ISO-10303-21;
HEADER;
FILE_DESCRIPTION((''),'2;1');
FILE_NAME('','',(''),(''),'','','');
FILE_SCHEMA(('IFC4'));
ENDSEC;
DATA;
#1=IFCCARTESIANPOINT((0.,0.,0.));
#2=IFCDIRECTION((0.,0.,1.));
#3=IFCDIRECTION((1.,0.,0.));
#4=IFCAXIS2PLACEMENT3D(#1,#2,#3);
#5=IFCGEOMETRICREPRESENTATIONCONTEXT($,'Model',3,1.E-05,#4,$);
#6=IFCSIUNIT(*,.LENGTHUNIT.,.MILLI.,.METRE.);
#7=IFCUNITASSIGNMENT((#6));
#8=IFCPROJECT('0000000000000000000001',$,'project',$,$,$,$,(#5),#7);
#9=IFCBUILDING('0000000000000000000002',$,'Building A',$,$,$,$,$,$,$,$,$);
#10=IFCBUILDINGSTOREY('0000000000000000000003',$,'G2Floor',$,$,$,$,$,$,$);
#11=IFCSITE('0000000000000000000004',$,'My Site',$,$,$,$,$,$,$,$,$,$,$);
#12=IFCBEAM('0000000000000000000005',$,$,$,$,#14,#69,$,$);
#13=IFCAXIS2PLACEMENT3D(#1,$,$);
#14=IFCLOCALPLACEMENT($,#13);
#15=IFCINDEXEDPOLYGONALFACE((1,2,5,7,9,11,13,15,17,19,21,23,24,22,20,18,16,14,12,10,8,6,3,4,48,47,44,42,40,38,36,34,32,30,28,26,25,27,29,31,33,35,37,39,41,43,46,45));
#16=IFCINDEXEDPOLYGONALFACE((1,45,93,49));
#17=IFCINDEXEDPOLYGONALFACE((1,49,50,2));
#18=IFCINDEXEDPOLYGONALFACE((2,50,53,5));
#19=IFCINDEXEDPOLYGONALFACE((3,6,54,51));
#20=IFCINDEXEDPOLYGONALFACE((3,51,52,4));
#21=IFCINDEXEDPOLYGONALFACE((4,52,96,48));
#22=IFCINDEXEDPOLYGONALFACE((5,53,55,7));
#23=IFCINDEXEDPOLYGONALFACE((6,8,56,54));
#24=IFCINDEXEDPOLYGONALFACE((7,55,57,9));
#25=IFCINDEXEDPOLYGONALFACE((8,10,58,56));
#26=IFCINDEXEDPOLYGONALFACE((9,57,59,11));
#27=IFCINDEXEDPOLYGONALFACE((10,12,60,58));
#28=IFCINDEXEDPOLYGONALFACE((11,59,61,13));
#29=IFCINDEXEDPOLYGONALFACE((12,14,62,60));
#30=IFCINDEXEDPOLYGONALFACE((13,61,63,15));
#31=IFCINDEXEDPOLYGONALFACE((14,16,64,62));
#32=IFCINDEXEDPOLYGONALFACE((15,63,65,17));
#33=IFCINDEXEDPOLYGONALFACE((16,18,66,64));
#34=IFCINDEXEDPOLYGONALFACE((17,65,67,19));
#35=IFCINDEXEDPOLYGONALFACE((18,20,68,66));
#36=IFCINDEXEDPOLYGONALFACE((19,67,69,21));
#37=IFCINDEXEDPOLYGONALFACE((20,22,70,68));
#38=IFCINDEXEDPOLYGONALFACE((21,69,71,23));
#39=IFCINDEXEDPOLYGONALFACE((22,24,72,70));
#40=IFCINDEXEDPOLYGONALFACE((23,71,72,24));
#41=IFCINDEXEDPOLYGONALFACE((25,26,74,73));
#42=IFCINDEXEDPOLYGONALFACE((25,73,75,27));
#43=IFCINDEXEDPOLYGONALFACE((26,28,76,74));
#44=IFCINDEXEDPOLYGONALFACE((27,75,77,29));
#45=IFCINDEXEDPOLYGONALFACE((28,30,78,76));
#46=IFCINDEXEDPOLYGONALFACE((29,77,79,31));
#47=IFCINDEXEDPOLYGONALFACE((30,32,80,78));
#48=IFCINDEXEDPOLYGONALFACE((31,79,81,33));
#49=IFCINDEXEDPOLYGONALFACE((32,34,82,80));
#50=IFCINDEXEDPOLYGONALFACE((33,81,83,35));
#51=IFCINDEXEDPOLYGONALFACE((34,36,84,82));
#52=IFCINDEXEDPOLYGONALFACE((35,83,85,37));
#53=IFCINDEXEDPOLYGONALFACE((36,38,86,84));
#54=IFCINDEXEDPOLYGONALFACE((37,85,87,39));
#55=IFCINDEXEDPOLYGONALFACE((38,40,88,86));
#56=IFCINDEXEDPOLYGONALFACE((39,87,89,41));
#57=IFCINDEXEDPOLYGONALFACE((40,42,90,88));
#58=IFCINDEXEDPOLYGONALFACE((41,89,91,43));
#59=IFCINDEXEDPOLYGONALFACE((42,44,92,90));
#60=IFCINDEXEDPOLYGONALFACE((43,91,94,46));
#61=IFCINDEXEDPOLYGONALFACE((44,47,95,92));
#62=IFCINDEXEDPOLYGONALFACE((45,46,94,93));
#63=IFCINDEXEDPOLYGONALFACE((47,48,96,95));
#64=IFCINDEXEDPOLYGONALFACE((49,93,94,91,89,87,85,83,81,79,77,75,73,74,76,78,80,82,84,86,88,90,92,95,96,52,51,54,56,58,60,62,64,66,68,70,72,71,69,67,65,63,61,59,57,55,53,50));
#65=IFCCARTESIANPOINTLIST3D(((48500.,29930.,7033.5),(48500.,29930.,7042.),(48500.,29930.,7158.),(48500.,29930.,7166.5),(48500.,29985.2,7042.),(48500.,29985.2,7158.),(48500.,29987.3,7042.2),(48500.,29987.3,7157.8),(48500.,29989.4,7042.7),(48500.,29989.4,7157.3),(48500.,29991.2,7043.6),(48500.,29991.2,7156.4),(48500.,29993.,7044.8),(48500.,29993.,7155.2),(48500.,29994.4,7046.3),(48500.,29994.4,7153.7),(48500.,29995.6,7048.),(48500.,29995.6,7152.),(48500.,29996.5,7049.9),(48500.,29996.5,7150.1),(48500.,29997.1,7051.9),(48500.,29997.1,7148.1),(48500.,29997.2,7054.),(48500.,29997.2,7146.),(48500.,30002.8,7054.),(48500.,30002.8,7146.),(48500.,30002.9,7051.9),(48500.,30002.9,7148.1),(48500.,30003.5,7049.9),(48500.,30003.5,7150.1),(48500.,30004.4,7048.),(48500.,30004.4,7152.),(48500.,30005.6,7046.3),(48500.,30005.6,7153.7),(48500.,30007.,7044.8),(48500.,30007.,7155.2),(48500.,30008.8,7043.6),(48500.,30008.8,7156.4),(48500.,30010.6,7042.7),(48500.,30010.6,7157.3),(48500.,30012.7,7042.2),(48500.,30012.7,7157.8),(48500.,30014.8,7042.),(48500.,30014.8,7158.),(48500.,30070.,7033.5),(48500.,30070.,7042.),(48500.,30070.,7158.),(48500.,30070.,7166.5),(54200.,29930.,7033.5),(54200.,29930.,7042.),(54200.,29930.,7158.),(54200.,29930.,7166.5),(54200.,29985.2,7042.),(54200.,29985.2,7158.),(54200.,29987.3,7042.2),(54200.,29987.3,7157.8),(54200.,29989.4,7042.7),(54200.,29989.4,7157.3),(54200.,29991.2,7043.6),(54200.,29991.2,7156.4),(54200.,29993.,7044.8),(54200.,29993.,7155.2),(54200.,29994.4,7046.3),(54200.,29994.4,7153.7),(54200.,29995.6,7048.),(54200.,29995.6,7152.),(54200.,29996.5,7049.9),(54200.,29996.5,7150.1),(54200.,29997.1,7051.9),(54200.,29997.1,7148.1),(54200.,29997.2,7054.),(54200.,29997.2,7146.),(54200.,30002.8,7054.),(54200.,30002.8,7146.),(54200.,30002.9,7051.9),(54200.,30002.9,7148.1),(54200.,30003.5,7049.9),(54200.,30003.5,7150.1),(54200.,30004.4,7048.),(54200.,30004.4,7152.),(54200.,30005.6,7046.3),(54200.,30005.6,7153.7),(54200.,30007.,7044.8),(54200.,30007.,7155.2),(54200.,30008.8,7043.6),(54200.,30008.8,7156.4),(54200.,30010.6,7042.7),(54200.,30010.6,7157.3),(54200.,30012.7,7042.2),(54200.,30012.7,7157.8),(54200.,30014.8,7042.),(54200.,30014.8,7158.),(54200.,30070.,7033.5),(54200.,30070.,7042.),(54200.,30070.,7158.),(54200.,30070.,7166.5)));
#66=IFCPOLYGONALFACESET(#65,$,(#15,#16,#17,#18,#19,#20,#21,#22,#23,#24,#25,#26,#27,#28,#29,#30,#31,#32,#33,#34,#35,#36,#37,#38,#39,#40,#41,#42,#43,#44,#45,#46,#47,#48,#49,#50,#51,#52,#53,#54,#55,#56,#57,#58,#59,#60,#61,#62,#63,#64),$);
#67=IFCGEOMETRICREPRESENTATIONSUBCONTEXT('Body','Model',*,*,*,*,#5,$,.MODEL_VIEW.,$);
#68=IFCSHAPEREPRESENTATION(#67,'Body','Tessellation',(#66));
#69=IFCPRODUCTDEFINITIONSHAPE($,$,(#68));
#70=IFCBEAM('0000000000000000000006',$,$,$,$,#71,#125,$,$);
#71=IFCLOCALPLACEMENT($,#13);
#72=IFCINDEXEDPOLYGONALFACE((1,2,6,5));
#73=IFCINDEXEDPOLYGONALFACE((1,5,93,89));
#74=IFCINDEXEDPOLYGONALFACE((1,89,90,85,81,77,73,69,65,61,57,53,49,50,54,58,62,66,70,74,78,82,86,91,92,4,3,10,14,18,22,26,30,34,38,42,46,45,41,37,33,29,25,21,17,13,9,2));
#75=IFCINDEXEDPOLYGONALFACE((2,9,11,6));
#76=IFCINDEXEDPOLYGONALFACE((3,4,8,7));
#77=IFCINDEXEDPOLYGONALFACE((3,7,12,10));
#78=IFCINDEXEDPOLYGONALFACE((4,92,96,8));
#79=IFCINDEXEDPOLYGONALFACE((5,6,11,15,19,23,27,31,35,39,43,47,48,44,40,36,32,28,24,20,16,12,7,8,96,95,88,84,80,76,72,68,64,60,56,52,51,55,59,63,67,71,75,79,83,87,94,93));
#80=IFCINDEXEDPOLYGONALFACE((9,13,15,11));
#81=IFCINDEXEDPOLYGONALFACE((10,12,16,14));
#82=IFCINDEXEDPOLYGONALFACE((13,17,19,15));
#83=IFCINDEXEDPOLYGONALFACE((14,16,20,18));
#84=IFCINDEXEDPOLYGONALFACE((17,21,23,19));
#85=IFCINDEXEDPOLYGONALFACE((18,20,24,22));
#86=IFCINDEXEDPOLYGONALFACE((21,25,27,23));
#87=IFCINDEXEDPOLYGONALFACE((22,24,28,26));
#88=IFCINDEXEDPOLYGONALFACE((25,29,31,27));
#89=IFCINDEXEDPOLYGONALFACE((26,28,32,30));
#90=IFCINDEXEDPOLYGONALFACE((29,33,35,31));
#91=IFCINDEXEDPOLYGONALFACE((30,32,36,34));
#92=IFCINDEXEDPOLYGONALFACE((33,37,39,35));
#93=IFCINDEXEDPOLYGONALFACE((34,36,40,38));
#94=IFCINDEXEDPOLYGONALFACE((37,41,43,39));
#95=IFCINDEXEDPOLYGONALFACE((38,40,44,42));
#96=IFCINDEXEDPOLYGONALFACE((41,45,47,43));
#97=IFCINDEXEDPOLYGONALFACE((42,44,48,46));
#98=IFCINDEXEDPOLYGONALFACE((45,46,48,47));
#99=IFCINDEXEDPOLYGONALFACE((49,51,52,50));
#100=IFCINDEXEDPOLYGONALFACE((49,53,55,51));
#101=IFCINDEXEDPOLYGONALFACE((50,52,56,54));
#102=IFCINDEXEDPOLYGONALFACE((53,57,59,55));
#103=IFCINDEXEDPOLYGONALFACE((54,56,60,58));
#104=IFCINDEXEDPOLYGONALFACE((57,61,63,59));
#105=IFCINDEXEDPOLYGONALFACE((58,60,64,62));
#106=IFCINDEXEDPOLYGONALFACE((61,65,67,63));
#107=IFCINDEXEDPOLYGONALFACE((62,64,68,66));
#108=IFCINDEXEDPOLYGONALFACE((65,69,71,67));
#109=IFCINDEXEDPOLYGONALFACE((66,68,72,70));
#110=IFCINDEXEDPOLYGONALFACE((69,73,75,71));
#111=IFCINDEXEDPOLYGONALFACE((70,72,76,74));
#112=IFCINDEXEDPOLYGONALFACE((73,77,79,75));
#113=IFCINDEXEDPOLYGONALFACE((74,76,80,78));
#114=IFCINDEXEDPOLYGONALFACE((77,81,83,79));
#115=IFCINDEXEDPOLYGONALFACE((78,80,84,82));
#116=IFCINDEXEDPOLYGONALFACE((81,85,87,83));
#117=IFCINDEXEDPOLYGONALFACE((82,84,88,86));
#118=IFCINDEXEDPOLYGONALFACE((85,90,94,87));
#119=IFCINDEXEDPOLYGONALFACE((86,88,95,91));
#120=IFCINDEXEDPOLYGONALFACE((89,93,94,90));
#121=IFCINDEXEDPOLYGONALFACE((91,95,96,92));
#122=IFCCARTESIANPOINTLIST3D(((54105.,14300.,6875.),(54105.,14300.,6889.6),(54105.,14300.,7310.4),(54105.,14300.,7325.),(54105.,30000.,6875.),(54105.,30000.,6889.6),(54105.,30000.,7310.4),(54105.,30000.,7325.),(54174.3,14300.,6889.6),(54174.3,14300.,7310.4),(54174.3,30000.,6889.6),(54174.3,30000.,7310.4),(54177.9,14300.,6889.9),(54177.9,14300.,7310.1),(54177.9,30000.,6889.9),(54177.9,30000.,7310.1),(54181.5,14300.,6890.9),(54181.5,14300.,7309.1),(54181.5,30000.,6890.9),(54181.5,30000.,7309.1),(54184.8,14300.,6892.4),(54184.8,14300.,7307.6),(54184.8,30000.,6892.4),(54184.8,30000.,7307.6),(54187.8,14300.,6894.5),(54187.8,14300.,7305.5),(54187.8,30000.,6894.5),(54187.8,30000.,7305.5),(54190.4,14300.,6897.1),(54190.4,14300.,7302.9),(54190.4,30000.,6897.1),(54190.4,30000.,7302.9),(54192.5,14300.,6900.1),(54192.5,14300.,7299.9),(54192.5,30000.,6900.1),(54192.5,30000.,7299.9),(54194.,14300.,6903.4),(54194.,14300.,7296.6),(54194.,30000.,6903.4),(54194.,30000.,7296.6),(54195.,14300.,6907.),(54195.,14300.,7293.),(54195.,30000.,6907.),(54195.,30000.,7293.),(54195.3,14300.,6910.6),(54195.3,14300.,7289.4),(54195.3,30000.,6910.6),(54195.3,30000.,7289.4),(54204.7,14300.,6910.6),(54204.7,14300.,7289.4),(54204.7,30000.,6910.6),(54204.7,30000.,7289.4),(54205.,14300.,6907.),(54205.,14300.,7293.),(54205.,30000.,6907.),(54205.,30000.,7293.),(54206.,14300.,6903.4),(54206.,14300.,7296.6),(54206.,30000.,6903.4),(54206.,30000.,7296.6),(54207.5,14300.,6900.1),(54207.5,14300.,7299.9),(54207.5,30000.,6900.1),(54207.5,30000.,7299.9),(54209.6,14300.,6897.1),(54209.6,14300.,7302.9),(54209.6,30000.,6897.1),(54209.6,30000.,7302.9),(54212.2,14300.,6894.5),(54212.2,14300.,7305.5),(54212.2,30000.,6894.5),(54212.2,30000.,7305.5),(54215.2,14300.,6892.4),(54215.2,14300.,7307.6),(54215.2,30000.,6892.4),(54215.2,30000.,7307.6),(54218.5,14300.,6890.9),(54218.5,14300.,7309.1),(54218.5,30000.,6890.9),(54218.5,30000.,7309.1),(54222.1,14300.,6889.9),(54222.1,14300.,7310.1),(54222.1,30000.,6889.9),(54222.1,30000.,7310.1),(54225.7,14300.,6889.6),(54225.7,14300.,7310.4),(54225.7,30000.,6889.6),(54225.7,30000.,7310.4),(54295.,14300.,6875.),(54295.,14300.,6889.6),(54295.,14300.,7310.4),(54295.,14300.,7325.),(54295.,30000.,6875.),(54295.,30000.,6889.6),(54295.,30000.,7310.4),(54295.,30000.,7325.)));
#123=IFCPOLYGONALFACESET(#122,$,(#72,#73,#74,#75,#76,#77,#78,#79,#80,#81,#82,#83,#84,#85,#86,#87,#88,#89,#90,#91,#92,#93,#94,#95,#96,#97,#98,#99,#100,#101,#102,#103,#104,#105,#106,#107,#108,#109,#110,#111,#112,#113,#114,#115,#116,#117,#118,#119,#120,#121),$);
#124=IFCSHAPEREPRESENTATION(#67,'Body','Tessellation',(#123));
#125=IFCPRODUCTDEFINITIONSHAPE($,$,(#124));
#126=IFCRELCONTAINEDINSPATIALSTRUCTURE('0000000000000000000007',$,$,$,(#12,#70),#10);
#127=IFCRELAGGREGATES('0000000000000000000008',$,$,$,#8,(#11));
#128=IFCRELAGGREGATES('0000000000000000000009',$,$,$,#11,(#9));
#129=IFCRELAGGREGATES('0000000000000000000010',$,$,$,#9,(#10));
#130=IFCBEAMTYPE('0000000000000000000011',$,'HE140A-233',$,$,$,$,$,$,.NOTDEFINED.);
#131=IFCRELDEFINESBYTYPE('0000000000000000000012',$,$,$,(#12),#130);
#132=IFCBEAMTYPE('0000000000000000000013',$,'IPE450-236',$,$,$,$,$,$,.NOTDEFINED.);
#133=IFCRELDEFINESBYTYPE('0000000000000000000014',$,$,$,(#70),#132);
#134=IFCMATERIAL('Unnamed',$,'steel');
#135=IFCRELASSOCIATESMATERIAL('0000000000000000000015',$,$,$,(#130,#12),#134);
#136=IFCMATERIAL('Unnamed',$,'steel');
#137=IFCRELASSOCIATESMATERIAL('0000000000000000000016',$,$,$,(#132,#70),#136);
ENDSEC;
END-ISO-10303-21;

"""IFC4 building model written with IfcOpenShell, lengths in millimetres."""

from ifc_helpers import new_model, si_unit, frame, origin_with_axes, place, context, subcontext, project, spatial, polyline, outline, extrude, material, material_profile, profile_set, profile_usage, type_object, element, save


model = new_model("IFC4")

# Units and contexts
model_context = context("Model", 3, precision=1e-05, world=origin_with_axes())
body_context = subcontext(model_context, "Body", "Model", "MODEL_VIEW")
ifc_project = project(units=[si_unit("LENGTHUNIT", "METRE", prefix="MILLI")], contexts=[model_context])

# Site, building, storey
site = spatial("IfcSite", under=ifc_project, Name="My Site")
building = spatial("IfcBuilding", under=site, Name="Building A")
storey = spatial("IfcBuildingStorey", under=building, Name="G2Floor")

# Beams
ifc_material_1 = material(Name="Unnamed", Category="steel")
ifc_material_profile_1 = material_profile(ifc_material_1, outline(polyline([(70.0, -66.5), (70.0, -58.0), (70.0, -58.0), (14.8, -58.0), (14.8, -58.0), (12.7, -57.8), (12.7, -57.8), (10.6, -57.3), (10.6, -57.3), (8.8, -56.4), (8.8, -56.4), (7.0, -55.2), (7.0, -55.2), (5.6, -53.7), (5.6, -53.7), (4.4, -52.0), (4.4, -52.0), (3.5, -50.1), (3.5, -50.1), (2.9, -48.1), (2.9, -48.1), (2.8, -46.0), (2.8, -46.0), (2.8, 46.0), (2.8, 46.0), (2.9, 48.1), (2.9, 48.1), (3.5, 50.1), (3.5, 50.1), (4.4, 52.0), (4.4, 52.0), (5.6, 53.7), (5.6, 53.7), (7.0, 55.2), (7.0, 55.2), (8.8, 56.4), (8.8, 56.4), (10.6, 57.3), (10.6, 57.3), (12.7, 57.8), (12.7, 57.8), (14.8, 58.0), (14.8, 58.0), (70.0, 58.0), (70.0, 58.0), (70.0, 66.5), (70.0, 66.5), (-70.0, 66.5), (-70.0, 66.5), (-70.0, 58.0), (-70.0, 58.0), (-14.8, 58.0), (-14.8, 58.0), (-12.7, 57.8), (-12.7, 57.8), (-10.6, 57.3), (-10.6, 57.3), (-8.8, 56.4), (-8.8, 56.4), (-7.0, 55.2), (-7.0, 55.2), (-5.6, 53.7), (-5.6, 53.7), (-4.4, 52.0), (-4.4, 52.0), (-3.5, 50.1), (-3.5, 50.1), (-2.9, 48.1), (-2.9, 48.1), (-2.8, 46.0), (-2.8, 46.0), (-2.8, -46.0), (-2.8, -46.0), (-2.9, -48.1), (-2.9, -48.1), (-3.5, -50.1), (-3.5, -50.1), (-4.4, -52.0), (-4.4, -52.0), (-5.6, -53.7), (-5.6, -53.7), (-7.0, -55.2), (-7.0, -55.2), (-8.8, -56.4), (-8.8, -56.4), (-10.6, -57.3), (-10.6, -57.3), (-12.7, -57.8), (-12.7, -57.8), (-14.8, -58.0), (-14.8, -58.0), (-70.0, -58.0), (-70.0, -58.0), (-70.0, -66.5), (-70.0, -66.5), (70.0, -66.5)])))
ifc_profile_set_1 = profile_set([ifc_material_profile_1], Name="HE140A-233")
ifc_profile_usage_1 = profile_usage(ifc_profile_set_1)
beam_type_1 = type_object("IfcBeamType", Name="HE140A-233", PredefinedType="NOTDEFINED", material=ifc_profile_set_1)
beam_1_placement = place(None, frame((48500.0, 30000.0, 7100.0), z_axis=(1.0, 0.0, 0.0), x_axis=(0.0, -1.0, 0.0)))
element("IfcBeam", 1, at=beam_1_placement, inside=storey, type_object=beam_type_1, material=ifc_profile_usage_1, context=body_context, shape_type="SweptSolid", body=[
    extrude(outline(polyline([(70.0, -66.5), (70.0, -58.0), (70.0, -58.0), (14.8, -58.0), (14.8, -58.0), (12.7, -57.8), (12.7, -57.8), (10.6, -57.3), (10.6, -57.3), (8.8, -56.4), (8.8, -56.4), (7.0, -55.2), (7.0, -55.2), (5.6, -53.7), (5.6, -53.7), (4.4, -52.0), (4.4, -52.0), (3.5, -50.1), (3.5, -50.1), (2.9, -48.1), (2.9, -48.1), (2.8, -46.0), (2.8, -46.0), (2.8, 46.0), (2.8, 46.0), (2.9, 48.1), (2.9, 48.1), (3.5, 50.1), (3.5, 50.1), (4.4, 52.0), (4.4, 52.0), (5.6, 53.7), (5.6, 53.7), (7.0, 55.2), (7.0, 55.2), (8.8, 56.4), (8.8, 56.4), (10.6, 57.3), (10.6, 57.3), (12.7, 57.8), (12.7, 57.8), (14.8, 58.0), (14.8, 58.0), (70.0, 58.0), (70.0, 58.0), (70.0, 66.5), (70.0, 66.5), (-70.0, 66.5), (-70.0, 66.5), (-70.0, 58.0), (-70.0, 58.0), (-14.8, 58.0), (-14.8, 58.0), (-12.7, 57.8), (-12.7, 57.8), (-10.6, 57.3), (-10.6, 57.3), (-8.8, 56.4), (-8.8, 56.4), (-7.0, 55.2), (-7.0, 55.2), (-5.6, 53.7), (-5.6, 53.7), (-4.4, 52.0), (-4.4, 52.0), (-3.5, 50.1), (-3.5, 50.1), (-2.9, 48.1), (-2.9, 48.1), (-2.8, 46.0), (-2.8, 46.0), (-2.8, -46.0), (-2.8, -46.0), (-2.9, -48.1), (-2.9, -48.1), (-3.5, -50.1), (-3.5, -50.1), (-4.4, -52.0), (-4.4, -52.0), (-5.6, -53.7), (-5.6, -53.7), (-7.0, -55.2), (-7.0, -55.2), (-8.8, -56.4), (-8.8, -56.4), (-10.6, -57.3), (-10.6, -57.3), (-12.7, -57.8), (-12.7, -57.8), (-14.8, -58.0), (-14.8, -58.0), (-70.0, -58.0), (-70.0, -58.0), (-70.0, -66.5), (-70.0, -66.5), (70.0, -66.5)])), origin_with_axes(), (0.0, 0.0, 1.0), 5700.0),
])
ifc_material_2 = material(Name="Unnamed", Category="steel")
ifc_material_profile_2 = material_profile(ifc_material_2, outline(polyline([(95.0, -225.0), (95.0, -210.4), (95.0, -210.4), (25.7, -210.4), (25.7, -210.4), (22.1, -210.1), (22.1, -210.1), (18.5, -209.1), (18.5, -209.1), (15.2, -207.6), (15.2, -207.6), (12.2, -205.5), (12.2, -205.5), (9.6, -202.9), (9.6, -202.9), (7.5, -199.9), (7.5, -199.9), (6.0, -196.6), (6.0, -196.6), (5.0, -193.0), (5.0, -193.0), (4.7, -189.4), (4.7, -189.4), (4.7, 189.4), (4.7, 189.4), (5.0, 193.0), (5.0, 193.0), (6.0, 196.6), (6.0, 196.6), (7.5, 199.9), (7.5, 199.9), (9.6, 202.9), (9.6, 202.9), (12.2, 205.5), (12.2, 205.5), (15.2, 207.6), (15.2, 207.6), (18.5, 209.1), (18.5, 209.1), (22.1, 210.1), (22.1, 210.1), (25.7, 210.4), (25.7, 210.4), (95.0, 210.4), (95.0, 210.4), (95.0, 225.0), (95.0, 225.0), (-95.0, 225.0), (-95.0, 225.0), (-95.0, 210.4), (-95.0, 210.4), (-25.7, 210.4), (-25.7, 210.4), (-22.1, 210.1), (-22.1, 210.1), (-18.5, 209.1), (-18.5, 209.1), (-15.2, 207.6), (-15.2, 207.6), (-12.2, 205.5), (-12.2, 205.5), (-9.6, 202.9), (-9.6, 202.9), (-7.5, 199.9), (-7.5, 199.9), (-6.0, 196.6), (-6.0, 196.6), (-5.0, 193.0), (-5.0, 193.0), (-4.7, 189.4), (-4.7, 189.4), (-4.7, -189.4), (-4.7, -189.4), (-5.0, -193.0), (-5.0, -193.0), (-6.0, -196.6), (-6.0, -196.6), (-7.5, -199.9), (-7.5, -199.9), (-9.6, -202.9), (-9.6, -202.9), (-12.2, -205.5), (-12.2, -205.5), (-15.2, -207.6), (-15.2, -207.6), (-18.5, -209.1), (-18.5, -209.1), (-22.1, -210.1), (-22.1, -210.1), (-25.7, -210.4), (-25.7, -210.4), (-95.0, -210.4), (-95.0, -210.4), (-95.0, -225.0), (-95.0, -225.0), (95.0, -225.0)])))
ifc_profile_set_2 = profile_set([ifc_material_profile_2], Name="IPE450-236")
ifc_profile_usage_2 = profile_usage(ifc_profile_set_2)
beam_type_2 = type_object("IfcBeamType", Name="IPE450-236", PredefinedType="NOTDEFINED", material=ifc_profile_set_2)
beam_2_placement = place(None, frame((54200.0, 14300.0, 7100.0), z_axis=(0.0, 1.0, 0.0), x_axis=(1.0, 0.0, 0.0)))
element("IfcBeam", 2, at=beam_2_placement, inside=storey, type_object=beam_type_2, material=ifc_profile_usage_2, context=body_context, shape_type="SweptSolid", body=[
    extrude(outline(polyline([(95.0, -225.0), (95.0, -210.4), (95.0, -210.4), (25.7, -210.4), (25.7, -210.4), (22.1, -210.1), (22.1, -210.1), (18.5, -209.1), (18.5, -209.1), (15.2, -207.6), (15.2, -207.6), (12.2, -205.5), (12.2, -205.5), (9.6, -202.9), (9.6, -202.9), (7.5, -199.9), (7.5, -199.9), (6.0, -196.6), (6.0, -196.6), (5.0, -193.0), (5.0, -193.0), (4.7, -189.4), (4.7, -189.4), (4.7, 189.4), (4.7, 189.4), (5.0, 193.0), (5.0, 193.0), (6.0, 196.6), (6.0, 196.6), (7.5, 199.9), (7.5, 199.9), (9.6, 202.9), (9.6, 202.9), (12.2, 205.5), (12.2, 205.5), (15.2, 207.6), (15.2, 207.6), (18.5, 209.1), (18.5, 209.1), (22.1, 210.1), (22.1, 210.1), (25.7, 210.4), (25.7, 210.4), (95.0, 210.4), (95.0, 210.4), (95.0, 225.0), (95.0, 225.0), (-95.0, 225.0), (-95.0, 225.0), (-95.0, 210.4), (-95.0, 210.4), (-25.7, 210.4), (-25.7, 210.4), (-22.1, 210.1), (-22.1, 210.1), (-18.5, 209.1), (-18.5, 209.1), (-15.2, 207.6), (-15.2, 207.6), (-12.2, 205.5), (-12.2, 205.5), (-9.6, 202.9), (-9.6, 202.9), (-7.5, 199.9), (-7.5, 199.9), (-6.0, 196.6), (-6.0, 196.6), (-5.0, 193.0), (-5.0, 193.0), (-4.7, 189.4), (-4.7, 189.4), (-4.7, -189.4), (-4.7, -189.4), (-5.0, -193.0), (-5.0, -193.0), (-6.0, -196.6), (-6.0, -196.6), (-7.5, -199.9), (-7.5, -199.9), (-9.6, -202.9), (-9.6, -202.9), (-12.2, -205.5), (-12.2, -205.5), (-15.2, -207.6), (-15.2, -207.6), (-18.5, -209.1), (-18.5, -209.1), (-22.1, -210.1), (-22.1, -210.1), (-25.7, -210.4), (-25.7, -210.4), (-95.0, -210.4), (-95.0, -210.4), (-95.0, -225.0), (-95.0, -225.0), (95.0, -225.0)])), origin_with_axes(), (0.0, 0.0, 1.0), 15700.0),
])

save(model, "model.ifc")
